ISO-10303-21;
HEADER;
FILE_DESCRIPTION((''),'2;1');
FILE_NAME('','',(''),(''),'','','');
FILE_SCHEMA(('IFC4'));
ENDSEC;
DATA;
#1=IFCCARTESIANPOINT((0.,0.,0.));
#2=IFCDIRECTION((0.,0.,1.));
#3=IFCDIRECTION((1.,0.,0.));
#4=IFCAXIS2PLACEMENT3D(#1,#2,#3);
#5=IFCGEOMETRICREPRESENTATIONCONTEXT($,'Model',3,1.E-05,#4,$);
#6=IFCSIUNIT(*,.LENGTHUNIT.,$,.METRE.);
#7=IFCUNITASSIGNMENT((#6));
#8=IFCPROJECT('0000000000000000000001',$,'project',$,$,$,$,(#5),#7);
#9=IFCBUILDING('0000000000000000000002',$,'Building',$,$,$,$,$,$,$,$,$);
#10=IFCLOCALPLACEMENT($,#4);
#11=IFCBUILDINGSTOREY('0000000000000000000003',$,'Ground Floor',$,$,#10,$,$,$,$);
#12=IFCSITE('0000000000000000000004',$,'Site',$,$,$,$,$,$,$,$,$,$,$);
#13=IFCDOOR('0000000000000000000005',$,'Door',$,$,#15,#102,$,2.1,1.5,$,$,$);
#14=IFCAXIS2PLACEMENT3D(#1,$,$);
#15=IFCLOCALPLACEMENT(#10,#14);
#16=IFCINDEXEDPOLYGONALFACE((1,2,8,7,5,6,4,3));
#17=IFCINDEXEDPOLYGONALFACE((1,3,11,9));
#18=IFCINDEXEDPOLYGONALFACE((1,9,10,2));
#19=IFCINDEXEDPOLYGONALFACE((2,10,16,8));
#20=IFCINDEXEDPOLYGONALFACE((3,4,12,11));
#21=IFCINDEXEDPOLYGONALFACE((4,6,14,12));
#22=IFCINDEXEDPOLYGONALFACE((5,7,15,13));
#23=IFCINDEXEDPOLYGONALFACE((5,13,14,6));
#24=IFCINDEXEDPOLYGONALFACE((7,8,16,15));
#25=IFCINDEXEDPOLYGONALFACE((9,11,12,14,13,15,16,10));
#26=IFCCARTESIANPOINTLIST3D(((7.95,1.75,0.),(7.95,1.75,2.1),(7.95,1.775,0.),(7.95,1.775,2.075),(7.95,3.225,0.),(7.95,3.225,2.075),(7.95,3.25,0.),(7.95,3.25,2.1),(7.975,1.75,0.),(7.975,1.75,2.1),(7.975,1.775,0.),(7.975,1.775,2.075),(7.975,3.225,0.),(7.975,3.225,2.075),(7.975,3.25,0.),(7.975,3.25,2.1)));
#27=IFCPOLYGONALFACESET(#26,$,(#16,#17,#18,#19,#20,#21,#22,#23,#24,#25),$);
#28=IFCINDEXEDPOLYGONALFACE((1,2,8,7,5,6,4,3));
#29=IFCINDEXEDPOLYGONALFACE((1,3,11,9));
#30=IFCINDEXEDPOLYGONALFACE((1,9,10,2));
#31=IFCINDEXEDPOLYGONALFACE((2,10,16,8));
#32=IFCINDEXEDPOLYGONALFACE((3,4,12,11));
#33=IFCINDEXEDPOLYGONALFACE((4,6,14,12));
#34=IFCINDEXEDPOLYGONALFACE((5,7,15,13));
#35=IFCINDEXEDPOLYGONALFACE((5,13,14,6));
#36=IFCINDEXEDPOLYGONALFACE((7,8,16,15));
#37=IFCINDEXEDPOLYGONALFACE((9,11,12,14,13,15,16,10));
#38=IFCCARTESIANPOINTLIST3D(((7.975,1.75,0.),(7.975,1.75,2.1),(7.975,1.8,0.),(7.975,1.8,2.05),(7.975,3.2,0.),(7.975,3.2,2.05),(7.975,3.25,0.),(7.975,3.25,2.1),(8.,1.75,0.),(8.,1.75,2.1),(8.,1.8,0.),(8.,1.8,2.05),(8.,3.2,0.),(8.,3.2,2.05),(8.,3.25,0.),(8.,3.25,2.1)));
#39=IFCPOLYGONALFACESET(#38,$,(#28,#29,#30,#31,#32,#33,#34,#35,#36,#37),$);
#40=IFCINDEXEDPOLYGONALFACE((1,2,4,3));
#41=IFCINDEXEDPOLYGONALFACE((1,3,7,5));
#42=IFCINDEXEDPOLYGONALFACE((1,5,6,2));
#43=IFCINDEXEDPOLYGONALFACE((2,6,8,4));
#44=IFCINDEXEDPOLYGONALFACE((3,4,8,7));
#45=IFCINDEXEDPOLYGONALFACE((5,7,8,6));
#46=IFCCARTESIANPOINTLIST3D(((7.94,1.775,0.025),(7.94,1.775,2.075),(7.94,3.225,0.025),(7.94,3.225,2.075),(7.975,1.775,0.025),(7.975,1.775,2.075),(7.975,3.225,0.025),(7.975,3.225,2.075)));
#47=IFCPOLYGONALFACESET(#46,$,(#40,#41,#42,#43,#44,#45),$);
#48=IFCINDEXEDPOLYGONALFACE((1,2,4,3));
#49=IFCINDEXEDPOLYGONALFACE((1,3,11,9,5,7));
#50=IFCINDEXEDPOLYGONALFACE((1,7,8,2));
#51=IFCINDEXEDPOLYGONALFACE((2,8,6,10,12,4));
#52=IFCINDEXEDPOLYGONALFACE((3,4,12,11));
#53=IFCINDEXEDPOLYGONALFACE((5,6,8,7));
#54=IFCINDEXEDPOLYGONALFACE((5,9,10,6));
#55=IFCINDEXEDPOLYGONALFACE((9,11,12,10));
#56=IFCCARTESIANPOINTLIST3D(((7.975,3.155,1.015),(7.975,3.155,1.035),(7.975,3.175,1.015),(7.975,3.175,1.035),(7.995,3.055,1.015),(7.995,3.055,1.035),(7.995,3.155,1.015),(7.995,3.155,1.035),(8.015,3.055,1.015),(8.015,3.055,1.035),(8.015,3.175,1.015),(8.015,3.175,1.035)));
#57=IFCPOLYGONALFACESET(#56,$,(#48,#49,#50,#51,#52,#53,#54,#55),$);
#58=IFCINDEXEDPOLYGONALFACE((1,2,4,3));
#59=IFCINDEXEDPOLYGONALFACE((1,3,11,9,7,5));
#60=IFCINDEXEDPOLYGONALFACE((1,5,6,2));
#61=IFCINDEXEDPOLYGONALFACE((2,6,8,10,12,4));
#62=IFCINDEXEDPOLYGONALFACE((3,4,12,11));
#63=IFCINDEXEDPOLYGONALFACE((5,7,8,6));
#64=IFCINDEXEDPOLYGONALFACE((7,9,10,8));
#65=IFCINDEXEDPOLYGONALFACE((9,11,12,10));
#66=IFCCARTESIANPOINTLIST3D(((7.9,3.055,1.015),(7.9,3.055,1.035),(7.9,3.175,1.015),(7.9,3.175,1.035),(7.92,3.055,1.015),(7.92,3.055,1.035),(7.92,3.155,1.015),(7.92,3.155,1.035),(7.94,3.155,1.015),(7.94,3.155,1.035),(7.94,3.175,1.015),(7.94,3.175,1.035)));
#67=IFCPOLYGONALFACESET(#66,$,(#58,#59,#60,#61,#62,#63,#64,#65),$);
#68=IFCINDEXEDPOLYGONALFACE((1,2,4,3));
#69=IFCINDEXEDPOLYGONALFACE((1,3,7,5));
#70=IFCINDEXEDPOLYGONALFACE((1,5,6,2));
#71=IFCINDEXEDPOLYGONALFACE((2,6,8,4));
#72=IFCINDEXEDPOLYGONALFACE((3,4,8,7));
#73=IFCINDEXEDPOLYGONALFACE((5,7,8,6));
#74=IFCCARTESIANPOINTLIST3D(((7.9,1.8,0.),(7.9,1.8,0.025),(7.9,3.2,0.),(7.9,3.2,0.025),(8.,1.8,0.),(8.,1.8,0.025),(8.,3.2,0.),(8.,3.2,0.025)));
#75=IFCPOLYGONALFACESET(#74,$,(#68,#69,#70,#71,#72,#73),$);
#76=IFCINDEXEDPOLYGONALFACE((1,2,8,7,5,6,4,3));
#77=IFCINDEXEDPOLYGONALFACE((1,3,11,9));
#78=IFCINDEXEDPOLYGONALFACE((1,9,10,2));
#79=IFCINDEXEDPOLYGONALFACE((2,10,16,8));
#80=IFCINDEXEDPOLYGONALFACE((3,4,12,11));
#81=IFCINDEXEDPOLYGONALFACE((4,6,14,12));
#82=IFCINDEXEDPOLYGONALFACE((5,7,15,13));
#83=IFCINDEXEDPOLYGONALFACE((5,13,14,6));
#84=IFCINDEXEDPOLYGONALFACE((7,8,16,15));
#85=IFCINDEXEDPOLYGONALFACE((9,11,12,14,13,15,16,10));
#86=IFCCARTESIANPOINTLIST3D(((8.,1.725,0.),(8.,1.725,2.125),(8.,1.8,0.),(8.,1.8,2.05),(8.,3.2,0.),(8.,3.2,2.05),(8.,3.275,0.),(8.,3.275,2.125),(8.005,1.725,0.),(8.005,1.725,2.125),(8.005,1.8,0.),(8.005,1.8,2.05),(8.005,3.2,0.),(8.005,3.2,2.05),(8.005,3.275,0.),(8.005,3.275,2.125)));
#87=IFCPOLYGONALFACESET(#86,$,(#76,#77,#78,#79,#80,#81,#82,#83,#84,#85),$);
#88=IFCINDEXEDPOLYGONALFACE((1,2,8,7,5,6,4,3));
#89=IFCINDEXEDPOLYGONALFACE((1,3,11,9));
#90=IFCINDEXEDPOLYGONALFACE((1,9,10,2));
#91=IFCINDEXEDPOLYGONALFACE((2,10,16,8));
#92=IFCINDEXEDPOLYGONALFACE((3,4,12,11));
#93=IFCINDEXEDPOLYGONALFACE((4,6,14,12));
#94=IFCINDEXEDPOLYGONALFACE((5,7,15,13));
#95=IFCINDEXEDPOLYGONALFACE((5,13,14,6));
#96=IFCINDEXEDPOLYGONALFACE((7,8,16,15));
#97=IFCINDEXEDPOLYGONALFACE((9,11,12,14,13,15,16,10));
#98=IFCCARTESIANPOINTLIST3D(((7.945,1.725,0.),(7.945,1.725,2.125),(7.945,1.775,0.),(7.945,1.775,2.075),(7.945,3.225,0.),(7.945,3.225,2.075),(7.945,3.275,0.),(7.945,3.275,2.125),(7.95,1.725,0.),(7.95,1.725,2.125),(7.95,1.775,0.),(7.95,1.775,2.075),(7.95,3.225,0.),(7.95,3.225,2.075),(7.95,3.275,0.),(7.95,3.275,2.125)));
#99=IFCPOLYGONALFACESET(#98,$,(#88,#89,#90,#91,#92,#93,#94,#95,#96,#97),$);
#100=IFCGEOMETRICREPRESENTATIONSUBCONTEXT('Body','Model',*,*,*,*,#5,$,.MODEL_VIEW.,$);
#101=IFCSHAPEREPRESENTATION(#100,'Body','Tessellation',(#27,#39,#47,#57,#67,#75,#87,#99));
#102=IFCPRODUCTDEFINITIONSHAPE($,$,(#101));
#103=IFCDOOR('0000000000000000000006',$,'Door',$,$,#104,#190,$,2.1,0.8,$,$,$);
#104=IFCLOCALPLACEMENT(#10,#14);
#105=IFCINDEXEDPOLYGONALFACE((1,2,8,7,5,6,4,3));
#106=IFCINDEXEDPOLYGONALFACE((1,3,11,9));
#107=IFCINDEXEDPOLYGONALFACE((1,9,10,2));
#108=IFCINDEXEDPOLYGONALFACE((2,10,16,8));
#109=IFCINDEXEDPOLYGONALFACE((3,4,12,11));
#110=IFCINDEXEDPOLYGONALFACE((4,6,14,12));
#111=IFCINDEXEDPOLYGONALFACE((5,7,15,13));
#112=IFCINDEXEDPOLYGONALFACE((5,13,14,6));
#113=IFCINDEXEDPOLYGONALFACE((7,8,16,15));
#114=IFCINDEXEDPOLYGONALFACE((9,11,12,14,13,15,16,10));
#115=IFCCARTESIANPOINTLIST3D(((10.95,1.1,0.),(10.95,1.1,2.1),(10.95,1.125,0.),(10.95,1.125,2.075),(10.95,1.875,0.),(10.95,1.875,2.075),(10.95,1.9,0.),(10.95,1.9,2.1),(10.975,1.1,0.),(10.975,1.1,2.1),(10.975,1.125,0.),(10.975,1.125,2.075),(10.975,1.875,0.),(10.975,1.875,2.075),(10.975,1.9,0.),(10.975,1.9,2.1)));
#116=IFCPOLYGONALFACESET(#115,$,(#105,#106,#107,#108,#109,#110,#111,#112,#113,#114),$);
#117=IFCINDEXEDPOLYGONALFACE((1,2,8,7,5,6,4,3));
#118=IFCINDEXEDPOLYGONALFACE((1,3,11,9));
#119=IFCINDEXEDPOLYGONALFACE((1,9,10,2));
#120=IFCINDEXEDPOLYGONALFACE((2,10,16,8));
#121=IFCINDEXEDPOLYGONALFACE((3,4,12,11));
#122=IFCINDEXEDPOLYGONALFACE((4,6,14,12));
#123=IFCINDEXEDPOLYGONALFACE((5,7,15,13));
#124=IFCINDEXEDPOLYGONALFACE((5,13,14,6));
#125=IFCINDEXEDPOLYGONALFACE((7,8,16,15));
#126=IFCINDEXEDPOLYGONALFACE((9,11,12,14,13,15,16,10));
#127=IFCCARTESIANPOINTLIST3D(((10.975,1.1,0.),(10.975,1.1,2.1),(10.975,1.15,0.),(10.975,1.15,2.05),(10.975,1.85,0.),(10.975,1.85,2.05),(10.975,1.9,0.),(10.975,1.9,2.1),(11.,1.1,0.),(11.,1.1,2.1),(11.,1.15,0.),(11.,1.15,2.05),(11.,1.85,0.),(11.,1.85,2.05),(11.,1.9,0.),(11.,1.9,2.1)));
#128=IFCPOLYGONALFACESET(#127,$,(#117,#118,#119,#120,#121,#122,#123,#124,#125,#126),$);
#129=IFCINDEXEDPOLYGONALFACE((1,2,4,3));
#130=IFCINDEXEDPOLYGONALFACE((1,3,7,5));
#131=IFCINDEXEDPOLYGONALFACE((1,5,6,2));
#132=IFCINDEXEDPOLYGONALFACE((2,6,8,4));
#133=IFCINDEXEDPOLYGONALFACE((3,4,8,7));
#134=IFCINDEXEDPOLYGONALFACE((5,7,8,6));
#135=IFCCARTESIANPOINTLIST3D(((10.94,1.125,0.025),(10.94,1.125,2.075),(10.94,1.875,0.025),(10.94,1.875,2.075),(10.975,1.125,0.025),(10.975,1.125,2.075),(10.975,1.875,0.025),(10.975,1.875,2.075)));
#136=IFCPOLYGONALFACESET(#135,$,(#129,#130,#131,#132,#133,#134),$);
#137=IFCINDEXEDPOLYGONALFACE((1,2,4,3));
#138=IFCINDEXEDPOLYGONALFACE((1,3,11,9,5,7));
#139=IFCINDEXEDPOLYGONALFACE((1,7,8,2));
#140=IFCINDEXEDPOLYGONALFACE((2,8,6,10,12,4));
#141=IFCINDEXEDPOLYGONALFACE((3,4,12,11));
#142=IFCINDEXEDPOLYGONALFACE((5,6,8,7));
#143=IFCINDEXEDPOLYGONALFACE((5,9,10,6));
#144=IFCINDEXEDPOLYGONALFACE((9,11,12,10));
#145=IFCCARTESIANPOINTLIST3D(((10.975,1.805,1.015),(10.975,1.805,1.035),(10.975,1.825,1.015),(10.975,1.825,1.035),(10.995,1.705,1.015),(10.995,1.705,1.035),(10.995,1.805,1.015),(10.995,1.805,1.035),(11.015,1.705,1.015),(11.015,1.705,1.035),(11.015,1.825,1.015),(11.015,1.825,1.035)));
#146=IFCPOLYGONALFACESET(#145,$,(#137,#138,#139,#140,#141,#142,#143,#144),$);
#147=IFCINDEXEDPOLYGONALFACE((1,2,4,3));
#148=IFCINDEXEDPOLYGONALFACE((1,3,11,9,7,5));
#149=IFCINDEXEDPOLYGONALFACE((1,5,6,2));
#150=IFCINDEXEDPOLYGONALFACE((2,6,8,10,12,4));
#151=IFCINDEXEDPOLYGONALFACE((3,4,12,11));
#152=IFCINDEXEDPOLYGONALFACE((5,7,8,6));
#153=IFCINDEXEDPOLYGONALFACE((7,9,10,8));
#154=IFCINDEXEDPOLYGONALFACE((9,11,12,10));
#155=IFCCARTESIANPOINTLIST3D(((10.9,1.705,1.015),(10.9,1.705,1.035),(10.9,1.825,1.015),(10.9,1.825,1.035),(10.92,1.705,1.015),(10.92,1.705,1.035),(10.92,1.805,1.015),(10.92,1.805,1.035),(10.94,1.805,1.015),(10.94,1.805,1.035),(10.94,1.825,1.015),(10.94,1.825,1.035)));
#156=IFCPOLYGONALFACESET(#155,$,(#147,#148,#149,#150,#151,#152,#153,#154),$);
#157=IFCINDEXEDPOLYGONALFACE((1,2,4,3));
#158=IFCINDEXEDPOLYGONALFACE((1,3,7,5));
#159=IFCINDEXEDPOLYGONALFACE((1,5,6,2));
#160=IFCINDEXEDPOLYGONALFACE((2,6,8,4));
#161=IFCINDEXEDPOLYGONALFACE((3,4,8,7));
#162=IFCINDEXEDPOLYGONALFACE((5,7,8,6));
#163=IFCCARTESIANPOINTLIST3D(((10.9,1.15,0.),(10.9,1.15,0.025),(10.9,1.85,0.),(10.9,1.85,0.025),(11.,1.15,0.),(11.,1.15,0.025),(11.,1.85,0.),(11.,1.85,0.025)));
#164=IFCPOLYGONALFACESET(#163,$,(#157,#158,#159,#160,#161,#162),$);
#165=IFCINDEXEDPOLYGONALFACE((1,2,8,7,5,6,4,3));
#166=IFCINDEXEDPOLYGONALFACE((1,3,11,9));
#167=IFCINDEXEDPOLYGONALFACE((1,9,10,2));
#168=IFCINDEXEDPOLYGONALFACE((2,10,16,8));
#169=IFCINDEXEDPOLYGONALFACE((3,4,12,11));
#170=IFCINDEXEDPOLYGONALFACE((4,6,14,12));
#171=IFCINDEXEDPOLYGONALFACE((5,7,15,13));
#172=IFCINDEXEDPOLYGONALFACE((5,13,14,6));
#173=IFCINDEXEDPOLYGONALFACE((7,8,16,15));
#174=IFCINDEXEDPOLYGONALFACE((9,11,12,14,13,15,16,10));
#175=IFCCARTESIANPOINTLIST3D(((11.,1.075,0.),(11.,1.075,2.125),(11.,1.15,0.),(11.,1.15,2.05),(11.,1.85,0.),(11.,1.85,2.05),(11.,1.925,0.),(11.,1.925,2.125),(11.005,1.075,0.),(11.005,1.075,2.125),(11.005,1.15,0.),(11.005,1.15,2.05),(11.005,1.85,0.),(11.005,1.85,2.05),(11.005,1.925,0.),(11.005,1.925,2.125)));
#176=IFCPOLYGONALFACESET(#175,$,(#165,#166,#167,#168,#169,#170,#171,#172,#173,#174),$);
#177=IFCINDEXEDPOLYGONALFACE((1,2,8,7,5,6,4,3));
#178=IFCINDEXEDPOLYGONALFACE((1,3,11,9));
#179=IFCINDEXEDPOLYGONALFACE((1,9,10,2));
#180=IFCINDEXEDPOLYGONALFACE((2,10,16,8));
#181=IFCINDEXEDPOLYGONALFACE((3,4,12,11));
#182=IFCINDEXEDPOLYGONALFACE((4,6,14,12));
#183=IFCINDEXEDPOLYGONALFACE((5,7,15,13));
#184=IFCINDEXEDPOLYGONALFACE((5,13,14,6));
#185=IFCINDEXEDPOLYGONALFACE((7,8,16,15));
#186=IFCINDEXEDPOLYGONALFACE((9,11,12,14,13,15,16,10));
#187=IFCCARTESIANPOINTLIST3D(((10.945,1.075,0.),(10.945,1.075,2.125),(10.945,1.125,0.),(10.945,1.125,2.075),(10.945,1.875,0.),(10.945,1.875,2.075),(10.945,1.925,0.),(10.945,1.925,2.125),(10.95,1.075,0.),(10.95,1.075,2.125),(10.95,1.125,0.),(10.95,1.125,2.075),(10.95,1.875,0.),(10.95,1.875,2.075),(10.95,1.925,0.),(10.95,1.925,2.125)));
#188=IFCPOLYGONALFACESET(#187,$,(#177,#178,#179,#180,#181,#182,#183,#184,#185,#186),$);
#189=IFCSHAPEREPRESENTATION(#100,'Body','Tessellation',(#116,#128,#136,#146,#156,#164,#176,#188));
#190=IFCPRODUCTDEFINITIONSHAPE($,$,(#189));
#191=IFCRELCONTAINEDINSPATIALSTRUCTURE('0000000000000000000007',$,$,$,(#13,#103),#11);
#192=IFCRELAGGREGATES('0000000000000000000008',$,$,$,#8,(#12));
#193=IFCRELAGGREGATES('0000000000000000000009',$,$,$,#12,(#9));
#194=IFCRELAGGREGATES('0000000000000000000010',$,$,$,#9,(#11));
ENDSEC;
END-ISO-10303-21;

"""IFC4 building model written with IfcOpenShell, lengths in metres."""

from ifc_helpers import new_model, si_unit, frame, origin_with_axes, place, context, subcontext, project, spatial, line, indexed_curve, outline, extrude, element, save


model = new_model("IFC4")

# Units and contexts
model_context = context("Model", 3, precision=1e-05, world=origin_with_axes())
body_context = subcontext(model_context, "Body", "Model", "MODEL_VIEW")
ifc_project = project(units=[si_unit("LENGTHUNIT", "METRE")], contexts=[model_context])

# Site, building, storey
site = spatial("IfcSite", under=ifc_project, Name="Site")
building = spatial("IfcBuilding", under=site, Name="Building")
storey_placement = place(None, origin_with_axes())
storey = spatial("IfcBuildingStorey", under=building, at=storey_placement, Name="Ground Floor")

# Doors
door_1_placement = place(storey_placement, frame((8.0, 1.75, 0.0), z_axis=(0.0, 0.0, 1.0), x_axis=(0.0, 1.0, 0.0)))
element("IfcDoor", 1, at=door_1_placement, inside=storey, Name="Door", OverallHeight=2.1, OverallWidth=1.5, context=body_context, shape_type="SweptSolid", body=[
    extrude(outline(indexed_curve([(0.0, 0.0), (0.0, 2.1), (1.5, 2.1), (1.5, 0.0), (1.475, 0.0), (1.475, 2.075), (0.025, 2.075), (0.025, 0.0)], segments=[line(1, 2, 3, 4, 5, 6, 7, 8, 1)])), frame((0.0, 0.025, 0.0), z_axis=(0.0, -1.0, 0.0), x_axis=(1.0, 0.0, 0.0)), (0.0, 0.0, -1.0), 0.025),
    extrude(outline(indexed_curve([(0.0, 0.0), (0.0, 2.1), (1.5, 2.1), (1.5, 0.0), (1.45, 0.0), (1.45, 2.05), (0.05, 2.05), (0.05, 0.0)], segments=[line(1, 2, 3, 4, 5, 6, 7, 8, 1)])), frame((0.0, 0.0, 0.0), z_axis=(0.0, -1.0, 0.0), x_axis=(1.0, 0.0, 0.0)), (0.0, 0.0, -1.0), 0.025),
    extrude(outline(indexed_curve([(0.0, 0.0), (1.45, 0.0), (1.45, 0.035), (0.0, 0.035)], segments=[line(1, 2, 3, 4, 1)])), frame((0.025, 0.025, 0.025), z_axis=(0.0, 0.0, 1.0), x_axis=(1.0, 0.0, 0.0)), (0.0, 0.0, 1.0), 2.05),
    extrude(outline(indexed_curve([(0.0, 0.0), (0.0, -0.04), (-0.12, -0.04), (-0.12, -0.02), (-0.02, -0.02), (-0.02, 0.0)], segments=[line(1, 2, 3, 4, 5, 6, 1)])), frame((1.425, 0.025, 1.015), z_axis=(0.0, 0.0, 1.0), x_axis=(1.0, 0.0, 0.0)), (0.0, 0.0, 1.0), 0.02),
    extrude(outline(indexed_curve([(0.0, 0.0), (0.0, 0.04), (-0.12, 0.04), (-0.12, 0.02), (-0.02, 0.02), (-0.02, 0.0)], segments=[line(1, 2, 3, 4, 5, 6, 1)])), frame((1.425, 0.06, 1.015), z_axis=(0.0, 0.0, 1.0), x_axis=(1.0, 0.0, 0.0)), (0.0, 0.0, 1.0), 0.02),
    extrude(outline(indexed_curve([(0.0, 0.0), (1.4, 0.0), (1.4, 0.1), (0.0, 0.1)], segments=[line(1, 2, 3, 4, 1)])), frame((0.05, 0.0, 0.0), z_axis=(0.0, 0.0, 1.0), x_axis=(1.0, 0.0, 0.0)), (0.0, 0.0, 1.0), 0.025),
    extrude(outline(indexed_curve([(0.0, 0.0), (0.0, 2.125), (1.55, 2.125), (1.55, 0.0), (1.475, 0.0), (1.475, 2.05), (0.075, 2.05), (0.075, 0.0)], segments=[line(1, 2, 3, 4, 5, 6, 7, 8, 1)])), frame((-0.025, -0.005, 0.0), z_axis=(0.0, -1.0, 0.0), x_axis=(1.0, 0.0, 0.0)), (0.0, 0.0, -1.0), 0.005),
    extrude(outline(indexed_curve([(0.0, 0.0), (0.0, 2.125), (1.55, 2.125), (1.55, 0.0), (1.5, 0.0), (1.5, 2.075), (0.05, 2.075), (0.05, 0.0)], segments=[line(1, 2, 3, 4, 5, 6, 7, 8, 1)])), frame((-0.025, 0.05, 0.0), z_axis=(0.0, -1.0, 0.0), x_axis=(1.0, 0.0, 0.0)), (0.0, 0.0, -1.0), 0.005),
])
door_2_placement = place(storey_placement, frame((11.0, 1.1, 0.0), z_axis=(0.0, 0.0, 1.0), x_axis=(0.0, 1.0, 0.0)))
element("IfcDoor", 2, at=door_2_placement, inside=storey, Name="Door", OverallHeight=2.1, OverallWidth=0.8, context=body_context, shape_type="SweptSolid", body=[
    extrude(outline(indexed_curve([(0.0, 0.0), (0.0, 2.1), (0.8, 2.1), (0.8, 0.0), (0.775, 0.0), (0.775, 2.075), (0.025, 2.075), (0.025, 0.0)], segments=[line(1, 2, 3, 4, 5, 6, 7, 8, 1)])), frame((0.0, 0.025, 0.0), z_axis=(0.0, -1.0, 0.0), x_axis=(1.0, 0.0, 0.0)), (0.0, 0.0, -1.0), 0.025),
    extrude(outline(indexed_curve([(0.0, 0.0), (0.0, 2.1), (0.8, 2.1), (0.8, 0.0), (0.75, 0.0), (0.75, 2.05), (0.05, 2.05), (0.05, 0.0)], segments=[line(1, 2, 3, 4, 5, 6, 7, 8, 1)])), frame((0.0, 0.0, 0.0), z_axis=(0.0, -1.0, 0.0), x_axis=(1.0, 0.0, 0.0)), (0.0, 0.0, -1.0), 0.025),
    extrude(outline(indexed_curve([(0.0, 0.0), (0.75, 0.0), (0.75, 0.035), (0.0, 0.035)], segments=[line(1, 2, 3, 4, 1)])), frame((0.025, 0.025, 0.025), z_axis=(0.0, 0.0, 1.0), x_axis=(1.0, 0.0, 0.0)), (0.0, 0.0, 1.0), 2.05),
    extrude(outline(indexed_curve([(0.0, 0.0), (0.0, -0.04), (-0.12, -0.04), (-0.12, -0.02), (-0.02, -0.02), (-0.02, 0.0)], segments=[line(1, 2, 3, 4, 5, 6, 1)])), frame((0.725, 0.025, 1.015), z_axis=(0.0, 0.0, 1.0), x_axis=(1.0, 0.0, 0.0)), (0.0, 0.0, 1.0), 0.02),
    extrude(outline(indexed_curve([(0.0, 0.0), (0.0, 0.04), (-0.12, 0.04), (-0.12, 0.02), (-0.02, 0.02), (-0.02, 0.0)], segments=[line(1, 2, 3, 4, 5, 6, 1)])), frame((0.725, 0.06, 1.015), z_axis=(0.0, 0.0, 1.0), x_axis=(1.0, 0.0, 0.0)), (0.0, 0.0, 1.0), 0.02),
    extrude(outline(indexed_curve([(0.0, 0.0), (0.7, 0.0), (0.7, 0.1), (0.0, 0.1)], segments=[line(1, 2, 3, 4, 1)])), frame((0.05, 0.0, 0.0), z_axis=(0.0, 0.0, 1.0), x_axis=(1.0, 0.0, 0.0)), (0.0, 0.0, 1.0), 0.025),
    extrude(outline(indexed_curve([(0.0, 0.0), (0.0, 2.125), (0.85, 2.125), (0.85, 0.0), (0.775, 0.0), (0.775, 2.05), (0.075, 2.05), (0.075, 0.0)], segments=[line(1, 2, 3, 4, 5, 6, 7, 8, 1)])), frame((-0.025, -0.005, 0.0), z_axis=(0.0, -1.0, 0.0), x_axis=(1.0, 0.0, 0.0)), (0.0, 0.0, -1.0), 0.005),
    extrude(outline(indexed_curve([(0.0, 0.0), (0.0, 2.125), (0.85, 2.125), (0.85, 0.0), (0.8, 0.0), (0.8, 2.075), (0.05, 2.075), (0.05, 0.0)], segments=[line(1, 2, 3, 4, 5, 6, 7, 8, 1)])), frame((-0.025, 0.05, 0.0), z_axis=(0.0, -1.0, 0.0), x_axis=(1.0, 0.0, 0.0)), (0.0, 0.0, -1.0), 0.005),
])

save(model, "model.ifc")
